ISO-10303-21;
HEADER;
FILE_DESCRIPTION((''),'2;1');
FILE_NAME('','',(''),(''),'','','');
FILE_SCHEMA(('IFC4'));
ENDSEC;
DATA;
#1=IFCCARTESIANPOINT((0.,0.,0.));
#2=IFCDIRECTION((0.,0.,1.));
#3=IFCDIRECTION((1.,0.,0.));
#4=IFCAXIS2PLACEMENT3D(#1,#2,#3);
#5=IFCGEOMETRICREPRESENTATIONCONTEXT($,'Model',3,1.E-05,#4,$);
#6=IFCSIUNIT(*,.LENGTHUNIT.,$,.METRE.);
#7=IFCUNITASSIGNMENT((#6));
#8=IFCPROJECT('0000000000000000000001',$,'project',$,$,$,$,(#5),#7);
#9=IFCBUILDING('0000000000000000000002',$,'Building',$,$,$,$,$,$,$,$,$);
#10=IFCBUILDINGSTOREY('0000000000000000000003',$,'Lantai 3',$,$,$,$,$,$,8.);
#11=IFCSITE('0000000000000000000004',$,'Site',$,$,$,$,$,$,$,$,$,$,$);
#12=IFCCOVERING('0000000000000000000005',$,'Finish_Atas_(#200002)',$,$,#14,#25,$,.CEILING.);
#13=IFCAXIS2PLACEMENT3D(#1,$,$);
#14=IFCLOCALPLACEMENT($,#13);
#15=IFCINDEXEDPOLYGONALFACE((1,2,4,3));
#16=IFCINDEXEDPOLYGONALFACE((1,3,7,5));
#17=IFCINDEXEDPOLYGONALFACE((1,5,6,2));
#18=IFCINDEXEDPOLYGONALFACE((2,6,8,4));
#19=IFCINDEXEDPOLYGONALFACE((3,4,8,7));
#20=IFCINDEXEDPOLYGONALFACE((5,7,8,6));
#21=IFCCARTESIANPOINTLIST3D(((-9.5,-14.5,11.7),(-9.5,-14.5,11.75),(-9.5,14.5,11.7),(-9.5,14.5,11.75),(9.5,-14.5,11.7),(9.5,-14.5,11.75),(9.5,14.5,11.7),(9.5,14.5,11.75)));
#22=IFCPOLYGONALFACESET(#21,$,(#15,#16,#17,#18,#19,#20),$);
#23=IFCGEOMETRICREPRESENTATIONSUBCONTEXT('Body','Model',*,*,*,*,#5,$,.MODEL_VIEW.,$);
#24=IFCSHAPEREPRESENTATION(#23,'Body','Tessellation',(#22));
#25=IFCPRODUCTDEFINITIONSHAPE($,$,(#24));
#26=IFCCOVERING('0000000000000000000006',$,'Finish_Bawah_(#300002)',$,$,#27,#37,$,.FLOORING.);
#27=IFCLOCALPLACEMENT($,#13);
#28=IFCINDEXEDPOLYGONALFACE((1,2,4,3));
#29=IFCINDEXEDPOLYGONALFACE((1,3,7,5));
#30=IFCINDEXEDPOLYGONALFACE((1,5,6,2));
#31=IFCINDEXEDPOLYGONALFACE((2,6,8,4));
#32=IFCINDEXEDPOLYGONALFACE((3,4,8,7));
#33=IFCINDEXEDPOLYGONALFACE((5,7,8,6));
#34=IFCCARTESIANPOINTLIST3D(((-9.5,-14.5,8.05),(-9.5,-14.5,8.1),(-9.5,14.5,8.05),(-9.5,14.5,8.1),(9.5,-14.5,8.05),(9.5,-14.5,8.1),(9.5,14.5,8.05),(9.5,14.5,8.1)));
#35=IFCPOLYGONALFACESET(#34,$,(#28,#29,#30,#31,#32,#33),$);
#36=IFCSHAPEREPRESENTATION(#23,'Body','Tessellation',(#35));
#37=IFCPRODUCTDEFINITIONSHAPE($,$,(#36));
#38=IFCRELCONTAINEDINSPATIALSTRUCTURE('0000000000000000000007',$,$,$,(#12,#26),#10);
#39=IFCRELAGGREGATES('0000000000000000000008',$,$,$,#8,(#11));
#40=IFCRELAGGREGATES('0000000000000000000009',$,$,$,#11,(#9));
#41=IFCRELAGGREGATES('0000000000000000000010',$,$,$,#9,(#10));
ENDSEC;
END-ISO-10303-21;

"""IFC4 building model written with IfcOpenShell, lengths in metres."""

from ifc_helpers import new_model, si_unit, frame, origin_with_axes, place, context, subcontext, project, spatial, polyline, outline, extrude, element, save


model = new_model("IFC4")

# Units and contexts
model_context = context("Model", 3, precision=1e-05, world=origin_with_axes())
body_context = subcontext(model_context, "Body", "Model", "MODEL_VIEW")
ifc_project = project(units=[si_unit("LENGTHUNIT", "METRE")], contexts=[model_context])

# Site, building, storey
site = spatial("IfcSite", under=ifc_project, Name="Site")
building = spatial("IfcBuilding", under=site, Name="Building")
storey = spatial("IfcBuildingStorey", under=building, Name="Lantai 3", Elevation=8.0)

# Coverings
covering_1_placement = place(None, origin_with_axes())
element("IfcCovering", 1, at=covering_1_placement, inside=storey, Name="Finish_Atas_(#200002)", PredefinedType="CEILING", context=body_context, shape_type="SweptSolid", body=[
    extrude(outline(polyline([(-9.5, -14.5), (9.5, -14.5), (9.5, 14.5), (-9.5, 14.5), (-9.5, -14.5)])), frame((0.0, 0.0, 11.7), z_axis=(0.0, 0.0, 1.0), x_axis=(1.0, 0.0, 0.0)), (0.0, 0.0, 1.0), 0.05),
])
covering_2_placement = place(None, origin_with_axes())
element("IfcCovering", 2, at=covering_2_placement, inside=storey, Name="Finish_Bawah_(#300002)", PredefinedType="FLOORING", context=body_context, shape_type="SweptSolid", body=[
    extrude(outline(polyline([(-9.5, -14.5), (9.5, -14.5), (9.5, 14.5), (-9.5, 14.5), (-9.5, -14.5)])), frame((0.0, 0.0, 8.05), z_axis=(0.0, 0.0, 1.0), x_axis=(1.0, 0.0, 0.0)), (0.0, 0.0, 1.0), 0.05),
])

save(model, "model.ifc")
